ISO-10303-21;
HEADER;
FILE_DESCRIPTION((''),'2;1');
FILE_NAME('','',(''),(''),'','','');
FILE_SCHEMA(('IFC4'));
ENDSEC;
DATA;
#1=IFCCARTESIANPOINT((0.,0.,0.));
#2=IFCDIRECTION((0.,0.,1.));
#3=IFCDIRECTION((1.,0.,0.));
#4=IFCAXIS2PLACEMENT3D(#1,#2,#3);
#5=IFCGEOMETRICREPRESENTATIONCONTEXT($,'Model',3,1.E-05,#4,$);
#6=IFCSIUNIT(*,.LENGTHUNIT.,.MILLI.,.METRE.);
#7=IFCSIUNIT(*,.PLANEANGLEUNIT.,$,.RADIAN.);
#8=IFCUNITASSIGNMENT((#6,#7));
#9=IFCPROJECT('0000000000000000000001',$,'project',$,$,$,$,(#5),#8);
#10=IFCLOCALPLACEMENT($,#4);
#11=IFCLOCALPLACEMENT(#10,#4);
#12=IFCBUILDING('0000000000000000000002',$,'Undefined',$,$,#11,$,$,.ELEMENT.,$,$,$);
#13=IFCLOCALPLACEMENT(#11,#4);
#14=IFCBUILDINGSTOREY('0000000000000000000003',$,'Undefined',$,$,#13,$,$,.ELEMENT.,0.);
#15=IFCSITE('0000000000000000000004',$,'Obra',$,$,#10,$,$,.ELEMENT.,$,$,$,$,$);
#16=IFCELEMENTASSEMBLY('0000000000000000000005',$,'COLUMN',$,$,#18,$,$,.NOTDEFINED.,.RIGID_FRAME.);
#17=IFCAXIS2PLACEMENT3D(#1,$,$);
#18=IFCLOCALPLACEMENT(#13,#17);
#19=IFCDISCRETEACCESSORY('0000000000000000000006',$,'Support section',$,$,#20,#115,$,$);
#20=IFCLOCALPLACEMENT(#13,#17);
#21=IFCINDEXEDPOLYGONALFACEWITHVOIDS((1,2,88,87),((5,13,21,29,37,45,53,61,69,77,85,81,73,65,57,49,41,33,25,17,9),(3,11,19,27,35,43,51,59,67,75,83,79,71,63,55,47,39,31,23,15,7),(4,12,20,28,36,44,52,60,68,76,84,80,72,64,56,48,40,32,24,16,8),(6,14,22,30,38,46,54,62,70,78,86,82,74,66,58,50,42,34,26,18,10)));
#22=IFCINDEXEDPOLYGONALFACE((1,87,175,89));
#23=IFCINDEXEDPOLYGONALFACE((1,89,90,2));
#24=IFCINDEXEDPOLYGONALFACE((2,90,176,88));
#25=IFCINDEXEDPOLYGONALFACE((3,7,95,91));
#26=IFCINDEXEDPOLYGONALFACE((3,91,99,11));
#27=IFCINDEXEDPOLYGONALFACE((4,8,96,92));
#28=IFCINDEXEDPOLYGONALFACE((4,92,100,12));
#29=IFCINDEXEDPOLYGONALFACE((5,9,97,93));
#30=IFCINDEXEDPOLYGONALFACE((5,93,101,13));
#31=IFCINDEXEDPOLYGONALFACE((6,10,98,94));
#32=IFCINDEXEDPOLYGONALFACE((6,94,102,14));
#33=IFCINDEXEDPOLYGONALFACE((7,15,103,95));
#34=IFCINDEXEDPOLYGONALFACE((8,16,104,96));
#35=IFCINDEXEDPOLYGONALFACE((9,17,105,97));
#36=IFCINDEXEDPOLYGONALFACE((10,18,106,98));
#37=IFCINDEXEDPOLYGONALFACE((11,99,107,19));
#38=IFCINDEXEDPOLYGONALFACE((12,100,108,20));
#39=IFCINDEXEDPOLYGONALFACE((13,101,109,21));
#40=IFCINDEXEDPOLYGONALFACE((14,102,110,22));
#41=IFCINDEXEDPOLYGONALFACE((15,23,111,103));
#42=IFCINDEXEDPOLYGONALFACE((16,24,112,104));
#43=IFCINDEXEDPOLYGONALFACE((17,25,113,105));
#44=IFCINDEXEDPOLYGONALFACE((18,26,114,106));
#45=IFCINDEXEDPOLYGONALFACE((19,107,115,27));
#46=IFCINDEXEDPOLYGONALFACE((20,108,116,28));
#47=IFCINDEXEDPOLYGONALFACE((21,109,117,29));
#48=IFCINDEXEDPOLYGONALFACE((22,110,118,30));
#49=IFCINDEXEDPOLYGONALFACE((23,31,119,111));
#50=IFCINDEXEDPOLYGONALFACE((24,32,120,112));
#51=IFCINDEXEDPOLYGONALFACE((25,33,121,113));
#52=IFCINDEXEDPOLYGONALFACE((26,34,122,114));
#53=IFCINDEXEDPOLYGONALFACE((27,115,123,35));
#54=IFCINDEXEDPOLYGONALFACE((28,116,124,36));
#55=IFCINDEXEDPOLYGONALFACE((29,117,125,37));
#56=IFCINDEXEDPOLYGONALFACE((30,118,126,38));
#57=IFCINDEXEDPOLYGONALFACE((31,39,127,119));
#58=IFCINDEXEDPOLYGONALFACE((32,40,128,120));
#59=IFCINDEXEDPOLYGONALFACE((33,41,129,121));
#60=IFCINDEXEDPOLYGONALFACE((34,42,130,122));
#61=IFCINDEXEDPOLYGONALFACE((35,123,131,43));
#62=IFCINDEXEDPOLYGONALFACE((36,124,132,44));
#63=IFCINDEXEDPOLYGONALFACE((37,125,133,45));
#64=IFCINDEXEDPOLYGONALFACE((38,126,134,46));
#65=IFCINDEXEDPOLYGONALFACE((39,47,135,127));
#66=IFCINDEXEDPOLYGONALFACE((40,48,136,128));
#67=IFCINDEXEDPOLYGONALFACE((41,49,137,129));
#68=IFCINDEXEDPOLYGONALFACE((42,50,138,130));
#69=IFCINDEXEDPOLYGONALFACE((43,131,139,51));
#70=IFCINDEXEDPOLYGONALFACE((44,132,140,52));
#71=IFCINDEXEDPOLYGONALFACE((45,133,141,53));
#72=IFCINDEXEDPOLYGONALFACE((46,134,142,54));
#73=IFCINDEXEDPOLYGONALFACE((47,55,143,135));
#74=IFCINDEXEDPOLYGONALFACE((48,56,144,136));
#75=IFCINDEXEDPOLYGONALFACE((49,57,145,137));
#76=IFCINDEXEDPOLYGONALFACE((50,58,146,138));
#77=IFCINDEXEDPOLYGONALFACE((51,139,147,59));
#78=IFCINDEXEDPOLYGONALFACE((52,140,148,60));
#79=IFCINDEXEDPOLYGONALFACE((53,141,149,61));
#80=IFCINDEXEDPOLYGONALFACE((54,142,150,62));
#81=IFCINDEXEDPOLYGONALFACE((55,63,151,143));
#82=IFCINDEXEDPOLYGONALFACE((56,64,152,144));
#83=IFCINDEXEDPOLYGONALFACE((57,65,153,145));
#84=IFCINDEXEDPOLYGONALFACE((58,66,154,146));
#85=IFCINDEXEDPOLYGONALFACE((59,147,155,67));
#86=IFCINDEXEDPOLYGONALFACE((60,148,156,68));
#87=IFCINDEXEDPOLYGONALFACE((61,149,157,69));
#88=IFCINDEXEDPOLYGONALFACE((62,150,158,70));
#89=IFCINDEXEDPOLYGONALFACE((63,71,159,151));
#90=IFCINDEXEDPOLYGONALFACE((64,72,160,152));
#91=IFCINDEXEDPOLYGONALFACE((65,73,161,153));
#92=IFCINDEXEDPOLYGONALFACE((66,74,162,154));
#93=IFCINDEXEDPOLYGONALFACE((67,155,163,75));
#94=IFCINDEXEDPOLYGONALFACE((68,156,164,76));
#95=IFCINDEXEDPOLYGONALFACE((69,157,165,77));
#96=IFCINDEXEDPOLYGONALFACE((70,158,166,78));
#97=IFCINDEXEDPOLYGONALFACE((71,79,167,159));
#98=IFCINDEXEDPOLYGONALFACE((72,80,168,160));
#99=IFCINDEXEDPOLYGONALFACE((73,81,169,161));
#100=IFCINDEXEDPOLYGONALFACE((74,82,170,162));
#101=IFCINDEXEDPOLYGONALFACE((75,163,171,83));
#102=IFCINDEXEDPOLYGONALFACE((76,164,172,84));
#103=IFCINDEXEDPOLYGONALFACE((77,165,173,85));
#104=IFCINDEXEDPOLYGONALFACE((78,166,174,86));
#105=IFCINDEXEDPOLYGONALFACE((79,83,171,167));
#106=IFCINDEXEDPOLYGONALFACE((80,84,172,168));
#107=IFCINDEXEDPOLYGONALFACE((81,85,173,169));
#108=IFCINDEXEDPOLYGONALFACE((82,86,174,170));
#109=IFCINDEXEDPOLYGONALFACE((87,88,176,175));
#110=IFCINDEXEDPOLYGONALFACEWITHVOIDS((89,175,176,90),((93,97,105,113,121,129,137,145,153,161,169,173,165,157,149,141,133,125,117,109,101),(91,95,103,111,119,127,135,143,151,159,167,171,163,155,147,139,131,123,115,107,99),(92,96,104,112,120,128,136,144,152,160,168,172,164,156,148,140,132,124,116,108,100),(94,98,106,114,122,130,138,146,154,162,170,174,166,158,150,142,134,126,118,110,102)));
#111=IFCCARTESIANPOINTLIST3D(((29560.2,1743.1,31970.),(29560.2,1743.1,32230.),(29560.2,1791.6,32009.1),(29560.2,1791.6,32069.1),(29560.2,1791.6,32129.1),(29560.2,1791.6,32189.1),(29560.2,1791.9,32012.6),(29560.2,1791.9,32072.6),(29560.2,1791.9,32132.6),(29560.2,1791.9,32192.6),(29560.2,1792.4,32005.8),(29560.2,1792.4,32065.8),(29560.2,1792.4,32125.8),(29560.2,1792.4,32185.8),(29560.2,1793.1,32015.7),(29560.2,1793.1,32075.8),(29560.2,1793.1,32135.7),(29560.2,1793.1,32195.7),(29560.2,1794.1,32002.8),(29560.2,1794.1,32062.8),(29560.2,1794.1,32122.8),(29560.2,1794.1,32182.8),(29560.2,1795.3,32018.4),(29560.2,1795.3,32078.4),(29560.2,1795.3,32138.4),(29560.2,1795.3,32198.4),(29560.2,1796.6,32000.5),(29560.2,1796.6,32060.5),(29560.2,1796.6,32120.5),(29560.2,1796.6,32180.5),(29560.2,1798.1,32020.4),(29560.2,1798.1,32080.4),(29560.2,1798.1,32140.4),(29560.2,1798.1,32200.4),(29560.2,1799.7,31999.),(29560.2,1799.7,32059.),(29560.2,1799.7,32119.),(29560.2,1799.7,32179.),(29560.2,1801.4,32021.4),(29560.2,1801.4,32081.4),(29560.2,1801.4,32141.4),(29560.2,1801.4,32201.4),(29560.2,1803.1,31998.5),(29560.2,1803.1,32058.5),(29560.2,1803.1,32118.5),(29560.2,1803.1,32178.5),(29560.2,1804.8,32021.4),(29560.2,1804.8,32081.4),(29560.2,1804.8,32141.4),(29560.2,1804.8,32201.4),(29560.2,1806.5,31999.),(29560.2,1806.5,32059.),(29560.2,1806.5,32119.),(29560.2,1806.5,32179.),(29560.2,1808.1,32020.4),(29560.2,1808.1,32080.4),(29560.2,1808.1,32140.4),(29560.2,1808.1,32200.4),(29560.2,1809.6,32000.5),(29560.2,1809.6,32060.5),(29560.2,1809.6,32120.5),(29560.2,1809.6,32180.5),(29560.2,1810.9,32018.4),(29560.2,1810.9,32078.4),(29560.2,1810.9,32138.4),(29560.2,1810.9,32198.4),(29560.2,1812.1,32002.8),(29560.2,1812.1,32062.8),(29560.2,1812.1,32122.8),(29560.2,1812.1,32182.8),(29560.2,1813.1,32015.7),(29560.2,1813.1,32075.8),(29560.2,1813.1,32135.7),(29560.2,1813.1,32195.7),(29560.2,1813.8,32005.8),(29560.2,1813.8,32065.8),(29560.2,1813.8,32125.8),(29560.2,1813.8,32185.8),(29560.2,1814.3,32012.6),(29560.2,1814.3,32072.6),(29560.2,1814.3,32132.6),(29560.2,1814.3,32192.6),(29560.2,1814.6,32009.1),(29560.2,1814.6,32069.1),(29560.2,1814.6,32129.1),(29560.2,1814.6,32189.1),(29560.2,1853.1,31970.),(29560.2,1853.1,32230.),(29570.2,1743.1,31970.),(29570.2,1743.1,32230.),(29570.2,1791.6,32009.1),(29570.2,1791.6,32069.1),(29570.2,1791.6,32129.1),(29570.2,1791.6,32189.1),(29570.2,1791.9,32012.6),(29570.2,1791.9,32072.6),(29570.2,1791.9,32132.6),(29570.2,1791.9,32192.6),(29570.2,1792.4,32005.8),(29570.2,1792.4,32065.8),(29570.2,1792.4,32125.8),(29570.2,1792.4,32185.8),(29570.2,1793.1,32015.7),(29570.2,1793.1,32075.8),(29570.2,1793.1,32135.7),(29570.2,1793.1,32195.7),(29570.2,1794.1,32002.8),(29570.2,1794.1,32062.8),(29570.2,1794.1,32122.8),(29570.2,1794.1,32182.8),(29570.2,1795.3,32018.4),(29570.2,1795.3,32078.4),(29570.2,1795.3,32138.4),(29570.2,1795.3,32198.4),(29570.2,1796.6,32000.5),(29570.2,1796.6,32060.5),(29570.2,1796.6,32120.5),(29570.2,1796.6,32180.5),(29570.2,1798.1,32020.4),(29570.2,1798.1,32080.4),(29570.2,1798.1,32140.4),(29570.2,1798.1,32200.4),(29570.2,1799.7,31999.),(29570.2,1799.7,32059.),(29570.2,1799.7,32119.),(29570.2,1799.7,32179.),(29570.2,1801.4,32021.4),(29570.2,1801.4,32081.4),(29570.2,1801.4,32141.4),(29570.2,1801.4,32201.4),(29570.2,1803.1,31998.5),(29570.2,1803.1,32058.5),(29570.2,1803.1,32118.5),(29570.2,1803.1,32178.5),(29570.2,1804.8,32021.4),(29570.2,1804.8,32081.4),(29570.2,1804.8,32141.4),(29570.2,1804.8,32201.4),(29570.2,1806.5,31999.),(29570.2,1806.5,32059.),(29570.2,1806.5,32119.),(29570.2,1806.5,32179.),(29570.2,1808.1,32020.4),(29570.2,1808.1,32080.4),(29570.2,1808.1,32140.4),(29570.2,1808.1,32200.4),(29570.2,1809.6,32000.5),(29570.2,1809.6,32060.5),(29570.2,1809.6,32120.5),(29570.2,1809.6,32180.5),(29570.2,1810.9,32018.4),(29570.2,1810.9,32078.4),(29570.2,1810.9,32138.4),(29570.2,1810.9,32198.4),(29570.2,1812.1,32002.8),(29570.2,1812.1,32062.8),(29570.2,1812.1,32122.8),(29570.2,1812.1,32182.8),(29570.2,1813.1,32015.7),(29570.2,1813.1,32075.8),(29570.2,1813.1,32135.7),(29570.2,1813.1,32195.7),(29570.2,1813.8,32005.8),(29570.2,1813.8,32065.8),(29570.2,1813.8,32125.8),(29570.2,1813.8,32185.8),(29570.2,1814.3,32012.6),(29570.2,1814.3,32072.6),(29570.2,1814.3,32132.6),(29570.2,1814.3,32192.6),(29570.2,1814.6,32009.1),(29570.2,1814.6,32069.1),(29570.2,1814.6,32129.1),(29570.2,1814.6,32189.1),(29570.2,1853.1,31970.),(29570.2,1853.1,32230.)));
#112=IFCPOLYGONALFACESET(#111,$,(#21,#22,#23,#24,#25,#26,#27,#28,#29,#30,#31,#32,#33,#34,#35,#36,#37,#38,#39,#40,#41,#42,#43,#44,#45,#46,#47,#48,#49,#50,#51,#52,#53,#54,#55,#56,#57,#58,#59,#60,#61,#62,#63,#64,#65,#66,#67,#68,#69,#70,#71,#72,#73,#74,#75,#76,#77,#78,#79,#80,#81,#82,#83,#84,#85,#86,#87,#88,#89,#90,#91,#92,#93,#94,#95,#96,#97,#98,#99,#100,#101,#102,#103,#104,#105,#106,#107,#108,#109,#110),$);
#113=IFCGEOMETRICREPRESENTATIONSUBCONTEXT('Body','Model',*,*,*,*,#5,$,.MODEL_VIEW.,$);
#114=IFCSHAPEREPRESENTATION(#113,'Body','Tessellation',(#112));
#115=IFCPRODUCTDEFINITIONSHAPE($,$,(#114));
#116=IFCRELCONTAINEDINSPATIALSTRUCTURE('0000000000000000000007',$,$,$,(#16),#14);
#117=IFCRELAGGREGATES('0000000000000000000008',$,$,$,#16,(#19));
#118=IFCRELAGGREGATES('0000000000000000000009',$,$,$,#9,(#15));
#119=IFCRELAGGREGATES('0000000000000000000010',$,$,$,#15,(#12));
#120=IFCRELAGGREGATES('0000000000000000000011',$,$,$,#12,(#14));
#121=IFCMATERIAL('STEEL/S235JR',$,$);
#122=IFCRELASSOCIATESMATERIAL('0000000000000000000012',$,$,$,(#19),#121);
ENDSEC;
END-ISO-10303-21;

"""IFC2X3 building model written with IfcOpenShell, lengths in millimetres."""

from ifc_helpers import new_model, si_unit, frame, origin_with_axes, origin_2d_with_axis, place, context, subcontext, project, spatial, rectangle, circle, extrude, source, transform, mapped, material, element, aggregate, save


model = new_model("IFC2X3")

# Units and contexts
model_context = context("Model", 3, precision=1e-05, world=origin_with_axes())
body_context = subcontext(model_context, "Body", "Model", "MODEL_VIEW")
ifc_project = project(units=[si_unit("LENGTHUNIT", "METRE", prefix="MILLI"), si_unit("PLANEANGLEUNIT", "RADIAN")], contexts=[model_context])

# Site, building, storey
site_placement = place(None, origin_with_axes())
site = spatial("IfcSite", under=ifc_project, at=site_placement, Name="Obra", CompositionType="ELEMENT")
building_placement = place(site_placement, origin_with_axes())
building = spatial("IfcBuilding", under=site, at=building_placement, Name="Undefined", CompositionType="ELEMENT")
storey_placement = place(building_placement, origin_with_axes())
storey = spatial("IfcBuildingStorey", under=building, at=storey_placement, Name="Undefined", CompositionType="ELEMENT", Elevation=0.0)

# Shared definitions
ifc_material_1 = material(Name="STEEL/S235JR")

# Element assembly, discrete accessory, opening
assembly_1_placement = place(storey_placement, origin_with_axes())
assembly_1 = element("IfcElementAssembly", 1, at=assembly_1_placement, inside=storey, Name="COLUMN", AssemblyPlace="NOTDEFINED", PredefinedType="RIGID_FRAME")
discrete_accessory_placement = place(assembly_1_placement, frame((29565.2, 1798.1, 31970.0), z_axis=(0.0, 0.0, 1.0), x_axis=(0.0, -1.0, 0.0)))
discrete_accessory = element("IfcDiscreteAccessory", 2, at=discrete_accessory_placement, material=ifc_material_1, Name="Support section", context=body_context, shape_type="SweptSolid", body=[
    extrude(rectangle(XDim=10.0, YDim=110.0, at=origin_2d_with_axis()), frame((0.0, 0.0, 260.0), z_axis=(0.0, 0.0, -1.0), x_axis=(0.0, 1.0, 0.0)), (0.0, 0.0, 1.0), 260.0),
])
shared_shape_1 = source(origin_with_axes(), body_context, "Body", "SweptSolid", [
    extrude(circle(Radius=11.5, at=origin_2d_with_axis()), frame((0.0, -14.4, 0.0), z_axis=(0.0, 1.0, 0.0), x_axis=(1.0, 0.0, 0.0)), (0.0, 0.0, 1.0), 10.2),
])
opening_1_placement = place(assembly_1_placement, frame((29555.9, 1753.1, 32300.0), z_axis=(0.0, 1.0, 0.0), x_axis=(0.0, 0.0, -1.0)))
element("IfcOpeningElement", 3, at=opening_1_placement, cuts=discrete_accessory, ObjectType="Opening", context=body_context, shape_type="MappedRepresentation", body=[
    mapped(shared_shape_1, transform((110.0, 0.0, 50.0))),
    mapped(shared_shape_1, transform((170.0, 0.0, 50.0))),
    mapped(shared_shape_1, transform((230.0, 0.0, 50.0))),
    mapped(shared_shape_1, transform((290.0, 0.0, 50.0))),
])
aggregate(assembly_1, [discrete_accessory])

save(model, "model.ifc")
